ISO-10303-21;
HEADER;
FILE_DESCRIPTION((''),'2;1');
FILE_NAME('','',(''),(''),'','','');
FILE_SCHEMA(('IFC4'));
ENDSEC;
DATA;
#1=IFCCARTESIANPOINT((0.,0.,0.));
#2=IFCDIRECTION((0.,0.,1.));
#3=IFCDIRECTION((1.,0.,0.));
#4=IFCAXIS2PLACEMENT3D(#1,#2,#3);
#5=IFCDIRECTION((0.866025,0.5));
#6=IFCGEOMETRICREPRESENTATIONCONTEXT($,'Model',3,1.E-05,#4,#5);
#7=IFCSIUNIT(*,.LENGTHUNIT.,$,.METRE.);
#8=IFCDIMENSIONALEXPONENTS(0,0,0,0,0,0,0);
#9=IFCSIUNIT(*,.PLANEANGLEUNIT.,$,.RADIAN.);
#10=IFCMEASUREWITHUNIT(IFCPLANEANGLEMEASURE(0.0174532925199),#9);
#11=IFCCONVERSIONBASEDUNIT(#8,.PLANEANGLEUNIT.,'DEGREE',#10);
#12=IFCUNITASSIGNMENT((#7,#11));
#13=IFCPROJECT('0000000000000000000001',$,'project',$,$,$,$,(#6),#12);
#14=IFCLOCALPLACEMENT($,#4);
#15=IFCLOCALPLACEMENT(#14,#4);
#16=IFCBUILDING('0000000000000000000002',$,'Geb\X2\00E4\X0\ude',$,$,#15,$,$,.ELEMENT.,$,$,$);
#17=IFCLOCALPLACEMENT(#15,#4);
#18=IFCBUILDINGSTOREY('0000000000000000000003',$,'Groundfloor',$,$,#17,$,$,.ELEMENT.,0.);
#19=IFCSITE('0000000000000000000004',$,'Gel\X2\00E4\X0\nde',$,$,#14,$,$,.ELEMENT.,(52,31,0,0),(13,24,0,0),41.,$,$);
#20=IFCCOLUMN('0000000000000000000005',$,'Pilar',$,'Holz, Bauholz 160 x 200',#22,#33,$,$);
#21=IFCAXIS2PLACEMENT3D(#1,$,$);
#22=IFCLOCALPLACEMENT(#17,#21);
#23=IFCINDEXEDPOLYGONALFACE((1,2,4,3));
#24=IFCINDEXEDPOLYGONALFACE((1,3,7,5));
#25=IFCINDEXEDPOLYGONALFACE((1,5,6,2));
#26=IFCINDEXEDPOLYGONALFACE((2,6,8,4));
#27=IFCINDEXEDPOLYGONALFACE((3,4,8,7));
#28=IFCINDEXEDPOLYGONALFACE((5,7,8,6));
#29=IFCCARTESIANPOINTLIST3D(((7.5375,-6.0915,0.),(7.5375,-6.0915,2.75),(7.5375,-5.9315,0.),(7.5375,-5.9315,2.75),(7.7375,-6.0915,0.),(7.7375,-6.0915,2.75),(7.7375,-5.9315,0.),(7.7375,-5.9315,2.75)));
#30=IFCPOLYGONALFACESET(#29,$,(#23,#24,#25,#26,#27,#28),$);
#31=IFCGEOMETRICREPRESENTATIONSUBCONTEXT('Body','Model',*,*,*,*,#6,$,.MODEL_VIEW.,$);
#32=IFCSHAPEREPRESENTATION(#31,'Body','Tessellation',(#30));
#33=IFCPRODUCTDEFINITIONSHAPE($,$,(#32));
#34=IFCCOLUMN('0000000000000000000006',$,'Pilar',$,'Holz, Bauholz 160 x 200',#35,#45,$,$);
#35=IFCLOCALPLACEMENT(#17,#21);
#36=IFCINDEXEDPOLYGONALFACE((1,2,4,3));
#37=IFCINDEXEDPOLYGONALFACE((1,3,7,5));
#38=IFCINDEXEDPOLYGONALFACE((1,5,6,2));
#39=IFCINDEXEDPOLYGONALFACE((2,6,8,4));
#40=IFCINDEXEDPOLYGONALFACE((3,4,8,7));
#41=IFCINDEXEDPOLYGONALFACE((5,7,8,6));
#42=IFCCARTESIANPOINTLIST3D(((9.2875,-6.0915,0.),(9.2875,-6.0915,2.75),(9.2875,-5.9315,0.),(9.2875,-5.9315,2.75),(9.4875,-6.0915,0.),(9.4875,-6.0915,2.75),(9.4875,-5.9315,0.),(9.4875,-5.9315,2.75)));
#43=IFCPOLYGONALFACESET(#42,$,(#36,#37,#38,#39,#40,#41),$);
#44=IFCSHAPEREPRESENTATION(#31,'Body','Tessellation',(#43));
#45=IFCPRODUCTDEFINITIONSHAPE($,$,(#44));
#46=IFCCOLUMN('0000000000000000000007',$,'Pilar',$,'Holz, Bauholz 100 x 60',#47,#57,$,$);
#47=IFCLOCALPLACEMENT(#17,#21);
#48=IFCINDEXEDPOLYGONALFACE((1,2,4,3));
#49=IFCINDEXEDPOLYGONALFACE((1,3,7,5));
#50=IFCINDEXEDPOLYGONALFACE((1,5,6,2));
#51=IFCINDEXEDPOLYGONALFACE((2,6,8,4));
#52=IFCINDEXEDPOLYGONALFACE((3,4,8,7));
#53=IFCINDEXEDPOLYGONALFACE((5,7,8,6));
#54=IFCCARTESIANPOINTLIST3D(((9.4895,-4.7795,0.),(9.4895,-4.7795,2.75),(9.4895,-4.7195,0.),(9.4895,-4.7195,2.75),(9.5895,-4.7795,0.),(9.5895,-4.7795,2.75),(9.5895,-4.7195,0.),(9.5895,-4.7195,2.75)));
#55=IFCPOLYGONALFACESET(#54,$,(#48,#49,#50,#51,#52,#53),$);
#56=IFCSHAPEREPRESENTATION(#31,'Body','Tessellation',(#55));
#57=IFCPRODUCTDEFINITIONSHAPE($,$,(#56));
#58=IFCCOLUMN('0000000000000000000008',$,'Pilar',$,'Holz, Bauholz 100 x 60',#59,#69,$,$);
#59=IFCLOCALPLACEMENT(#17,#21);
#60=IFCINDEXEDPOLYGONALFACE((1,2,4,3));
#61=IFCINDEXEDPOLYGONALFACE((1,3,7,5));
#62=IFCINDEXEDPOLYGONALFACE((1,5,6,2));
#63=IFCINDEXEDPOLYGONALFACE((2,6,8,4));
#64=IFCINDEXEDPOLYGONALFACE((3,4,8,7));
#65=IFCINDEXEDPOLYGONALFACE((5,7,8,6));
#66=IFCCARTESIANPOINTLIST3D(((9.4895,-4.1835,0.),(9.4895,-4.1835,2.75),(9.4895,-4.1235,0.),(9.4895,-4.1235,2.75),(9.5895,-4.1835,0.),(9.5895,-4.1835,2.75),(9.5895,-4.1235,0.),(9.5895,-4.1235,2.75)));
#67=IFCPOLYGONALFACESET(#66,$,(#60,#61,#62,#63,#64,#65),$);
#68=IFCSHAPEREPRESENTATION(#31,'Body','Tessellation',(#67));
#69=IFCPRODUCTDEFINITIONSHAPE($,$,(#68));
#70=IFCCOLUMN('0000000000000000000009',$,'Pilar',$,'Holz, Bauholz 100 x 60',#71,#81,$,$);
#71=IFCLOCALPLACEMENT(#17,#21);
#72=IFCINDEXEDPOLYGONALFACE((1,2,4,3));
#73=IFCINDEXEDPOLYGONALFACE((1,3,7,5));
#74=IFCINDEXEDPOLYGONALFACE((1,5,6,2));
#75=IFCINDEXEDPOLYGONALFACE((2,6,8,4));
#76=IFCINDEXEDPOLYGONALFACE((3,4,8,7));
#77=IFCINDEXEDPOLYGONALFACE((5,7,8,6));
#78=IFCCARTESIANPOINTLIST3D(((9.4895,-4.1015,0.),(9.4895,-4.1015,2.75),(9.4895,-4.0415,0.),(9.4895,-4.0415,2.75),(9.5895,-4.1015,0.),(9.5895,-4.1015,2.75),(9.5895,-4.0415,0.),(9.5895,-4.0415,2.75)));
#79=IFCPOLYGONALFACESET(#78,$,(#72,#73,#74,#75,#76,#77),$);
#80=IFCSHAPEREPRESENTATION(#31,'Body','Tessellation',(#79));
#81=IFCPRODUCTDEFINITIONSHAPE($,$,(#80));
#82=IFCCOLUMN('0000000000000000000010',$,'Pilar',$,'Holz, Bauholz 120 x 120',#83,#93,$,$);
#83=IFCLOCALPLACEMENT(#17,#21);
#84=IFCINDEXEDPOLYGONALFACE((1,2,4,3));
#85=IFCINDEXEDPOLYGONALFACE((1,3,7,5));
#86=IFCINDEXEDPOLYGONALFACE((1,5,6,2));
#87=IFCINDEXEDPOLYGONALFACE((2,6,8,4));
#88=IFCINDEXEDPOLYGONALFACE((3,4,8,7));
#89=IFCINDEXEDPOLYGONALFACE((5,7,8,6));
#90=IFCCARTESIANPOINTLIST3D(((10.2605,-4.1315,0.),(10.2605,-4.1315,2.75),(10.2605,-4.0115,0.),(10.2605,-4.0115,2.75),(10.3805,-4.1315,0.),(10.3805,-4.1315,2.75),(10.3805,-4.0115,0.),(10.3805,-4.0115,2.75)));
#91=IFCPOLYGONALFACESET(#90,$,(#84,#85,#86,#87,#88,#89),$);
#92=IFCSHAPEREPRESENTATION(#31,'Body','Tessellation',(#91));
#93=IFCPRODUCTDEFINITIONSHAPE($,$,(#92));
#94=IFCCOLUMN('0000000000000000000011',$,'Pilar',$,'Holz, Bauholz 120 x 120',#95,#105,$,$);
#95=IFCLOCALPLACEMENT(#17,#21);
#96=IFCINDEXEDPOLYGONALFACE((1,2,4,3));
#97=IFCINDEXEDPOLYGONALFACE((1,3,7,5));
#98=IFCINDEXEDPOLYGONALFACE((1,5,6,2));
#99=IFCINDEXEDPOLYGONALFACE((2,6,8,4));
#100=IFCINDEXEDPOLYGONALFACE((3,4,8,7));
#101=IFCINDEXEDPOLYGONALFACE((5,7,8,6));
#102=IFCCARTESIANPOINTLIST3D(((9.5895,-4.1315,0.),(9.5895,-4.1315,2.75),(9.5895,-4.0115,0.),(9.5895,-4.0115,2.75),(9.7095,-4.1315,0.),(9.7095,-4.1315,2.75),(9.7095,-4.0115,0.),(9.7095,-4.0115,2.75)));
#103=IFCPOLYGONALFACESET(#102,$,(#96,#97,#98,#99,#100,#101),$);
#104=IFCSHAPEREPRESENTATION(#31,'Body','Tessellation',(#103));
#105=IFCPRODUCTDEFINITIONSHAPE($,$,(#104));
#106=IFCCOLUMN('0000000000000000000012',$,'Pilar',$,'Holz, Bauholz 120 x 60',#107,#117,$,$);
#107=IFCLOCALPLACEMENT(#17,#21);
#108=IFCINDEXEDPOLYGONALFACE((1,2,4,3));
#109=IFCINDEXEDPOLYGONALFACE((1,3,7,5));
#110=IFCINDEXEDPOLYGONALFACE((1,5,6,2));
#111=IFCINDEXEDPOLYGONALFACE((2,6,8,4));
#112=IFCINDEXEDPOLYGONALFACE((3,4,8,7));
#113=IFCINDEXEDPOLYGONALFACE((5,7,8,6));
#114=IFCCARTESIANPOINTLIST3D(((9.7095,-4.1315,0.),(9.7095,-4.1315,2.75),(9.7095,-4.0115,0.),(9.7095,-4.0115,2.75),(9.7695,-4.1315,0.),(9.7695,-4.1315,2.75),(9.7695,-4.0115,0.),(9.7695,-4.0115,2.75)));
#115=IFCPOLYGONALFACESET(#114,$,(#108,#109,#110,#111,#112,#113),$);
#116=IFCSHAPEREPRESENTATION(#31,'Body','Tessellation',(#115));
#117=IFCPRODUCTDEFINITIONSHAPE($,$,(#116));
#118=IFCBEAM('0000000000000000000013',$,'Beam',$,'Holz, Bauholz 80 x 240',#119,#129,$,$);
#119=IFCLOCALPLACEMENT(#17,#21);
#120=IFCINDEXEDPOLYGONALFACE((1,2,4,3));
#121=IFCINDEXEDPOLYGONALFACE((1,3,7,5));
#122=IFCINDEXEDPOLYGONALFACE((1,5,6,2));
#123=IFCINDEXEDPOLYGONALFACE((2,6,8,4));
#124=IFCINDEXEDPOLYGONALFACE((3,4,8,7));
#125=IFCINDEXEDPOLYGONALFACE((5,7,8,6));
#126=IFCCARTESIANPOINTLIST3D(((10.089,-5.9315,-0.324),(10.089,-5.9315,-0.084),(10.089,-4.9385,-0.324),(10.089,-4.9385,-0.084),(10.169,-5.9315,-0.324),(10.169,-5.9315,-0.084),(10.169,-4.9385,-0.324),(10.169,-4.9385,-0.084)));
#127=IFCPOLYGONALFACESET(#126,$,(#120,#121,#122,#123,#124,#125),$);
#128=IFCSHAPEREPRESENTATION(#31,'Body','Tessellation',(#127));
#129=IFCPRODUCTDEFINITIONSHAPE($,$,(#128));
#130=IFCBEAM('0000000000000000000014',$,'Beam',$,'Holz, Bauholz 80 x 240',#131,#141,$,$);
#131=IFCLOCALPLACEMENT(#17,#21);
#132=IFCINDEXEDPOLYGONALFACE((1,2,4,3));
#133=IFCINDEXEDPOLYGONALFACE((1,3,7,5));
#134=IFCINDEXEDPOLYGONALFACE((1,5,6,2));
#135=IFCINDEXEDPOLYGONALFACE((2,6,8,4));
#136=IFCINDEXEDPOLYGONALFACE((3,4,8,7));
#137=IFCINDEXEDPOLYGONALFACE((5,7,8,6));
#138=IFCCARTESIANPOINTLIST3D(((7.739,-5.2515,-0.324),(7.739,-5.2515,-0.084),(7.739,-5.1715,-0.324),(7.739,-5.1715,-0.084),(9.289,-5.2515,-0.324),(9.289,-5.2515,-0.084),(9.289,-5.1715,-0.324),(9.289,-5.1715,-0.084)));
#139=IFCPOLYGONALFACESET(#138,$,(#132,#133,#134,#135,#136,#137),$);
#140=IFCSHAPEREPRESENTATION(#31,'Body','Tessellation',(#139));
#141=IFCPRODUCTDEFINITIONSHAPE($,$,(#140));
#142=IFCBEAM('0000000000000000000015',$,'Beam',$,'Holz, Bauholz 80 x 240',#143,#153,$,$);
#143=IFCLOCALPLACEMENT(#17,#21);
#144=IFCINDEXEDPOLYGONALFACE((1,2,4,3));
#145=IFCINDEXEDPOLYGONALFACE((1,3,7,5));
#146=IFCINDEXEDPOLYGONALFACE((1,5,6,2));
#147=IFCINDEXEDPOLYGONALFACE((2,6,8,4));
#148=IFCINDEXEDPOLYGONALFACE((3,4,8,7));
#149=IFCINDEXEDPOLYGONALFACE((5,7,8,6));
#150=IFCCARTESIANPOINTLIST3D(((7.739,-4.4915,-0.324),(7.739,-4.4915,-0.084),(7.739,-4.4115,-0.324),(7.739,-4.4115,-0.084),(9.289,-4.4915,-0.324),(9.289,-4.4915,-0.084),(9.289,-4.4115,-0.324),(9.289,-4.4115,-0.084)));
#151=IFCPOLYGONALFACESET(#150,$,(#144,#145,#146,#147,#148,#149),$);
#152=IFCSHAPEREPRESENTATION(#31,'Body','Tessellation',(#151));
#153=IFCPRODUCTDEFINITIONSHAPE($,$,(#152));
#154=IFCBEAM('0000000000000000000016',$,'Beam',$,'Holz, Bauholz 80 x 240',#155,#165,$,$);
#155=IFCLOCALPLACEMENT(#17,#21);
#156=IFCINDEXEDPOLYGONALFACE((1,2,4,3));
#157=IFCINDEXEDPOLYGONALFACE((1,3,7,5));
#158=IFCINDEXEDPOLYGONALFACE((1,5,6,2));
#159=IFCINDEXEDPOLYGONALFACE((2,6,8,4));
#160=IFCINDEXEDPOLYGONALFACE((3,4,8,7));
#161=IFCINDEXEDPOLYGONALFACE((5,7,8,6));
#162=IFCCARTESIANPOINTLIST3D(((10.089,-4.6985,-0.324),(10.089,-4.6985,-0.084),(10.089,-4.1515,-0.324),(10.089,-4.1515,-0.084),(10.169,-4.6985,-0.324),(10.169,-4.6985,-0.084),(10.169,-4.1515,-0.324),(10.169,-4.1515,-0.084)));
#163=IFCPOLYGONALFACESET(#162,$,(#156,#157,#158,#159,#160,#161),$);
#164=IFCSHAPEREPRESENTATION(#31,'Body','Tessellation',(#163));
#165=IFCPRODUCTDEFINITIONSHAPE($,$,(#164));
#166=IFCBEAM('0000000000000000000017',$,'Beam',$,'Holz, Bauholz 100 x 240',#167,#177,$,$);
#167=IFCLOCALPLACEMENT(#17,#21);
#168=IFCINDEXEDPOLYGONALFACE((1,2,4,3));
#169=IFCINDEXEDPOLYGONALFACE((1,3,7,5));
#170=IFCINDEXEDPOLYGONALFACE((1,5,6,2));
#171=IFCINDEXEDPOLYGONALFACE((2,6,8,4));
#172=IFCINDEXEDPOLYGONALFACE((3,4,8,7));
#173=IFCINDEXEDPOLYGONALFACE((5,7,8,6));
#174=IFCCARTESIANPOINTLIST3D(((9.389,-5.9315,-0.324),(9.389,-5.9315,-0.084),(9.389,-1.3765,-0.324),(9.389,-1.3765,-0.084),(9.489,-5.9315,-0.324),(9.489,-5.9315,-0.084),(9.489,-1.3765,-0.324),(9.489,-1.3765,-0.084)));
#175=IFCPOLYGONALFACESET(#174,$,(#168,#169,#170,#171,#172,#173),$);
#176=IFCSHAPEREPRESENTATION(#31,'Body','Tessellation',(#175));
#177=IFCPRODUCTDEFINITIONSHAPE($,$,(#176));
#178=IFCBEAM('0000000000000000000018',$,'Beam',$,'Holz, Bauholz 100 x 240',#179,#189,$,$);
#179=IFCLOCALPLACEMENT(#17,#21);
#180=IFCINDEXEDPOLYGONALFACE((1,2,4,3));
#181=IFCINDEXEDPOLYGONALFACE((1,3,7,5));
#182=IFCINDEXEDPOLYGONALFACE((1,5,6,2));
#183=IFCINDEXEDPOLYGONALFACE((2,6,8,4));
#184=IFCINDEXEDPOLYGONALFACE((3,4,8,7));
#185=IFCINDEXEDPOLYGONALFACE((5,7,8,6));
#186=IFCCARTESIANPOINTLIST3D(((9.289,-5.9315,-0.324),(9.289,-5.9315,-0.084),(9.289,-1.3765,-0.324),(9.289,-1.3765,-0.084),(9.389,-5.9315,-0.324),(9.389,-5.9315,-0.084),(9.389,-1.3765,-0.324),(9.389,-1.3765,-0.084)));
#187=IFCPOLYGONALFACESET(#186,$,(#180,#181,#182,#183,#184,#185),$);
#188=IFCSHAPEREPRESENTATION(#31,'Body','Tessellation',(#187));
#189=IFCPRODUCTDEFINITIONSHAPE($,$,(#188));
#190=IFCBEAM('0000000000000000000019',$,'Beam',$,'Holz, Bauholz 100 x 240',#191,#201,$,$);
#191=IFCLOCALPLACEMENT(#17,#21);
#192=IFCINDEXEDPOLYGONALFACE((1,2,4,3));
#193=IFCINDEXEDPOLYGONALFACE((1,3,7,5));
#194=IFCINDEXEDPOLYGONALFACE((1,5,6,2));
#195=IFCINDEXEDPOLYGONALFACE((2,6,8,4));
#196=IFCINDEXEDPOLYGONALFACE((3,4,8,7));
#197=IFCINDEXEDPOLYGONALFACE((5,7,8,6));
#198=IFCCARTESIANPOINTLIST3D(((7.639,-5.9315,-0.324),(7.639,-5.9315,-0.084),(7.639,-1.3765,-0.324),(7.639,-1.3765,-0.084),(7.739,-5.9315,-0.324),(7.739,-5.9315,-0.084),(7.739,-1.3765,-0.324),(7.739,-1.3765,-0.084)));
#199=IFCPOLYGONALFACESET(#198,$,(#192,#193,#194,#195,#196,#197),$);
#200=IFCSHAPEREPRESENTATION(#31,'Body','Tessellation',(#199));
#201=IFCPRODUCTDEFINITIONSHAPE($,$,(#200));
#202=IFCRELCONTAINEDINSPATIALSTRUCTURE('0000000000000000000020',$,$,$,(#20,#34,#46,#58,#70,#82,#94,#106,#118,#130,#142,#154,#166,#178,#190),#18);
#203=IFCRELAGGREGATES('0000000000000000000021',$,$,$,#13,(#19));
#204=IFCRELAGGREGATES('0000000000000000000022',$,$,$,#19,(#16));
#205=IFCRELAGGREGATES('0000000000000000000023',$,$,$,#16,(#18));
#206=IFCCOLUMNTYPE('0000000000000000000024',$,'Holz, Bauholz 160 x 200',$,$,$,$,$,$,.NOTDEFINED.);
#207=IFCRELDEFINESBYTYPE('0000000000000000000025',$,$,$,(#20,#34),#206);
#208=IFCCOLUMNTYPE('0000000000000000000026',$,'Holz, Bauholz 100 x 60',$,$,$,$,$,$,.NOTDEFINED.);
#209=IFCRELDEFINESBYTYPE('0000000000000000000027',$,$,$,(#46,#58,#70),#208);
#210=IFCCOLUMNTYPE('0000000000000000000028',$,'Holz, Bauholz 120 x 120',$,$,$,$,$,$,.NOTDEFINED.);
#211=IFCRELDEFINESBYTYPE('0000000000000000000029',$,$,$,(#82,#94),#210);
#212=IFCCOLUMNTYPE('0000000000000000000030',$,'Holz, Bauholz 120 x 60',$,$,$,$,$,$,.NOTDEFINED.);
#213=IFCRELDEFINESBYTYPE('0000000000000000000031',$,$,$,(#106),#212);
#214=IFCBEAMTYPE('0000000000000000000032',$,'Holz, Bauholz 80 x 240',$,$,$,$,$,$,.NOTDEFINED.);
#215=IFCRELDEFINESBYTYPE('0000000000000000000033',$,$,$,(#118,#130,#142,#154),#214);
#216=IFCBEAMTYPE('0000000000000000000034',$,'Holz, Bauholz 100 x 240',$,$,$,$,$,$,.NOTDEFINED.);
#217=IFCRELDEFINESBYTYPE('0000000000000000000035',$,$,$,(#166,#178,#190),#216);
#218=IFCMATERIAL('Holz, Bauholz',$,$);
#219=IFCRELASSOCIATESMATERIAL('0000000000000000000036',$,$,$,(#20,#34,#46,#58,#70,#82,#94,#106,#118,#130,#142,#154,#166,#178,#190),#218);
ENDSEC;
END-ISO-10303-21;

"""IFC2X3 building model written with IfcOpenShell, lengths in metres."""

from ifc_helpers import new_model, entity, si_unit, converted_unit, direction, frame, frame_2d, origin_with_axes, origin_2d_with_axis, place, context, subcontext, project, spatial, rectangle, extrude, clip, halfspace, material, type_object, element, save


model = new_model("IFC2X3")

# Units and contexts
model_context = context("Model", 3, precision=1e-05, world=origin_with_axes(), true_north=direction((0.866025, 0.5)))
body_context = subcontext(model_context, "Body", "Model", "MODEL_VIEW")
ifc_project = project(units=[si_unit("LENGTHUNIT", "METRE"), converted_unit("PLANEANGLEUNIT", "DEGREE", entity("IfcPlaneAngleMeasure", 0.0174532925199), si_unit("PLANEANGLEUNIT", "RADIAN"), dimensions=[0, 0, 0, 0, 0, 0, 0])], contexts=[model_context])

# Site, building, storey
site_placement = place(None, origin_with_axes())
site = spatial("IfcSite", under=ifc_project, at=site_placement, Name="Gelände", CompositionType="ELEMENT", RefLatitude=(52, 31, 0, 0), RefLongitude=(13, 24, 0, 0), RefElevation=41.0)
building_placement = place(site_placement, origin_with_axes())
building = spatial("IfcBuilding", under=site, at=building_placement, Name="Gebäude", CompositionType="ELEMENT")
storey_placement = place(building_placement, origin_with_axes())
storey = spatial("IfcBuildingStorey", under=building, at=storey_placement, Name="Groundfloor", CompositionType="ELEMENT", Elevation=0.0)

# Columns
ifc_material_1 = material(Name="Holz, Bauholz")
column_type_1 = type_object("IfcColumnType", Name="Holz, Bauholz 160 x 200", PredefinedType="NOTDEFINED")
for number, where, z_axis, x_axis, name in (
    (1, (7.6375, -6.0115, 0.0), (0.0, 0.0, 1.0), (1.0, 0.0, 0.0), "Pilar"),
    (2, (9.3875, -6.0115, 0.0), (0.0, 0.0, 1.0), (1.0, 0.0, 0.0), "Pilar"),
):
    element("IfcColumn", number, at=place(storey_placement, frame(where, z_axis=z_axis, x_axis=x_axis)), inside=storey, type_object=column_type_1, material=ifc_material_1, Name=name, ObjectType="Holz, Bauholz 160 x 200", context=body_context, shape_type="Clipping", body=[
        clip(clip(extrude(rectangle(XDim=0.16, YDim=0.2, at=origin_2d_with_axis()), frame((0.0, 0.0, 0.0), z_axis=(0.0, 0.0, 1.0), x_axis=(0.0, 1.0, 0.0)), (0.0, 0.0, 1.0), 2.75), halfspace(frame((0.0, 0.0, 2.75), z_axis=(0.0, 0.0, -1.0), x_axis=(0.0, 1.0, 0.0)), True)), halfspace(frame((0.0, 0.0, 0.0), z_axis=(0.0, 0.0, 1.0), x_axis=(0.0, -1.0, 0.0)), True)),
    ])
column_type_2 = type_object("IfcColumnType", Name="Holz, Bauholz 100 x 60", PredefinedType="NOTDEFINED")
for number, where, z_axis, x_axis, name in (
    (3, (9.5395, -4.7495, 0.0), (0.0, 0.0, 1.0), (0.0, -1.0, 0.0), "Pilar"),
    (4, (9.5395, -4.1535, 0.0), (0.0, 0.0, 1.0), (0.0, -1.0, 0.0), "Pilar"),
    (5, (9.5395, -4.0715, 0.0), (0.0, 0.0, 1.0), (0.0, -1.0, 0.0), "Pilar"),
):
    element("IfcColumn", number, at=place(storey_placement, frame(where, z_axis=z_axis, x_axis=x_axis)), inside=storey, type_object=column_type_2, material=ifc_material_1, Name=name, ObjectType="Holz, Bauholz 100 x 60", context=body_context, shape_type="Clipping", body=[
        clip(clip(extrude(rectangle(XDim=0.1, YDim=0.06, at=origin_2d_with_axis()), frame((0.0, 0.0, 0.0), z_axis=(0.0, 0.0, 1.0), x_axis=(0.0, 1.0, 0.0)), (0.0, 0.0, 1.0), 2.75), halfspace(frame((0.0, 0.0, 2.75), z_axis=(0.0, 0.0, -1.0), x_axis=(0.0, 1.0, 0.0)), True)), halfspace(frame((0.0, 0.0, 0.0), z_axis=(0.0, 0.0, 1.0), x_axis=(0.0, -1.0, 0.0)), True)),
    ])
column_type_3 = type_object("IfcColumnType", Name="Holz, Bauholz 120 x 120", PredefinedType="NOTDEFINED")
for number, where, z_axis, x_axis, name in (
    (6, (10.3205, -4.0715, 0.0), (0.0, 0.0, 1.0), (1.0, 0.0, 0.0), "Pilar"),
    (7, (9.6495, -4.0715, 0.0), (0.0, 0.0, 1.0), (1.0, 0.0, 0.0), "Pilar"),
):
    element("IfcColumn", number, at=place(storey_placement, frame(where, z_axis=z_axis, x_axis=x_axis)), inside=storey, type_object=column_type_3, material=ifc_material_1, Name=name, ObjectType="Holz, Bauholz 120 x 120", context=body_context, shape_type="Clipping", body=[
        clip(clip(extrude(rectangle(XDim=0.12, YDim=0.12, at=origin_2d_with_axis()), frame((0.0, 0.0, 0.0), z_axis=(0.0, 0.0, 1.0), x_axis=(0.0, 1.0, 0.0)), (0.0, 0.0, 1.0), 2.75), halfspace(frame((0.0, 0.0, 2.75), z_axis=(0.0, 0.0, -1.0), x_axis=(0.0, 1.0, 0.0)), True)), halfspace(frame((0.0, 0.0, 0.0), z_axis=(0.0, 0.0, 1.0), x_axis=(0.0, -1.0, 0.0)), True)),
    ])
column_type_4 = type_object("IfcColumnType", Name="Holz, Bauholz 120 x 60", PredefinedType="NOTDEFINED")
column_placement = place(storey_placement, frame((9.7395, -4.0715, 0.0), z_axis=(0.0, 0.0, 1.0), x_axis=(1.0, 0.0, 0.0)))
element("IfcColumn", 8, at=column_placement, inside=storey, type_object=column_type_4, material=ifc_material_1, Name="Pilar", ObjectType="Holz, Bauholz 120 x 60", context=body_context, shape_type="Clipping", body=[
    clip(clip(extrude(rectangle(XDim=0.12, YDim=0.06, at=origin_2d_with_axis()), frame((0.0, 0.0, 0.0), z_axis=(0.0, 0.0, 1.0), x_axis=(0.0, 1.0, 0.0)), (0.0, 0.0, 1.0), 2.75), halfspace(frame((0.0, 0.0, 2.75), z_axis=(0.0, 0.0, -1.0), x_axis=(0.0, 1.0, 0.0)), True)), halfspace(frame((0.0, 0.0, 0.0), z_axis=(0.0, 0.0, 1.0), x_axis=(0.0, -1.0, 0.0)), True)),
])

# Beams
beam_type_1 = type_object("IfcBeamType", Name="Holz, Bauholz 80 x 240", PredefinedType="NOTDEFINED")
beam_1_placement = place(storey_placement, frame((10.129, -5.9315, -0.084), z_axis=(0.0, 0.0, 1.0), x_axis=(1.0, 0.0, 0.0)))
element("IfcBeam", 9, at=beam_1_placement, inside=storey, type_object=beam_type_1, material=ifc_material_1, Name="Beam", ObjectType="Holz, Bauholz 80 x 240", context=body_context, shape_type="SweptSolid", body=[
    extrude(rectangle(XDim=0.24, YDim=0.08, at=frame_2d((-0.12, 0.0), x_axis=(1.0, 0.0))), frame((0.0, 0.0, 0.0), z_axis=(0.0, 1.0, 0.0), x_axis=(0.0, 0.0, 1.0)), (0.0, 0.0, 1.0), 0.993),
])
for number, where, z_axis, x_axis, name in (
    (10, (9.289, -5.2115, -0.084), (0.0, 0.0, 1.0), (0.0, 1.0, 0.0), "Beam"),
    (11, (9.289, -4.4515, -0.084), (0.0, 0.0, 1.0), (0.0, 1.0, 0.0), "Beam"),
):
    element("IfcBeam", number, at=place(storey_placement, frame(where, z_axis=z_axis, x_axis=x_axis)), inside=storey, type_object=beam_type_1, material=ifc_material_1, Name=name, ObjectType="Holz, Bauholz 80 x 240", context=body_context, shape_type="SweptSolid", body=[
        extrude(rectangle(XDim=0.24, YDim=0.08, at=frame_2d((-0.12, 0.0), x_axis=(1.0, 0.0))), frame((0.0, 0.0, 0.0), z_axis=(0.0, 1.0, 0.0), x_axis=(0.0, 0.0, 1.0)), (0.0, 0.0, 1.0), 1.55),
    ])
beam_2_placement = place(storey_placement, frame((10.129, -4.6985, -0.084), z_axis=(0.0, 0.0, 1.0), x_axis=(1.0, 0.0, 0.0)))
element("IfcBeam", 12, at=beam_2_placement, inside=storey, type_object=beam_type_1, material=ifc_material_1, Name="Beam", ObjectType="Holz, Bauholz 80 x 240", context=body_context, shape_type="SweptSolid", body=[
    extrude(rectangle(XDim=0.24, YDim=0.08, at=frame_2d((-0.12, 0.0), x_axis=(1.0, 0.0))), frame((0.0, 0.0, 0.0), z_axis=(0.0, 1.0, 0.0), x_axis=(0.0, 0.0, 1.0)), (0.0, 0.0, 1.0), 0.547),
])
beam_type_2 = type_object("IfcBeamType", Name="Holz, Bauholz 100 x 240", PredefinedType="NOTDEFINED")
for number, where, z_axis, x_axis, name in (
    (13, (9.439, -5.9315, -0.084), (0.0, 0.0, 1.0), (1.0, 0.0, 0.0), "Beam"),
    (14, (9.339, -5.9315, -0.084), (0.0, 0.0, 1.0), (1.0, 0.0, 0.0), "Beam"),
    (15, (7.689, -5.9315, -0.084), (0.0, 0.0, 1.0), (1.0, 0.0, 0.0), "Beam"),
):
    element("IfcBeam", number, at=place(storey_placement, frame(where, z_axis=z_axis, x_axis=x_axis)), inside=storey, type_object=beam_type_2, material=ifc_material_1, Name=name, ObjectType="Holz, Bauholz 100 x 240", context=body_context, shape_type="SweptSolid", body=[
        extrude(rectangle(XDim=0.24, YDim=0.1, at=frame_2d((-0.12, 0.0), x_axis=(1.0, 0.0))), frame((0.0, 0.0, 0.0), z_axis=(0.0, 1.0, 0.0), x_axis=(0.0, 0.0, 1.0)), (0.0, 0.0, 1.0), 4.555),
    ])

save(model, "model.ifc")
